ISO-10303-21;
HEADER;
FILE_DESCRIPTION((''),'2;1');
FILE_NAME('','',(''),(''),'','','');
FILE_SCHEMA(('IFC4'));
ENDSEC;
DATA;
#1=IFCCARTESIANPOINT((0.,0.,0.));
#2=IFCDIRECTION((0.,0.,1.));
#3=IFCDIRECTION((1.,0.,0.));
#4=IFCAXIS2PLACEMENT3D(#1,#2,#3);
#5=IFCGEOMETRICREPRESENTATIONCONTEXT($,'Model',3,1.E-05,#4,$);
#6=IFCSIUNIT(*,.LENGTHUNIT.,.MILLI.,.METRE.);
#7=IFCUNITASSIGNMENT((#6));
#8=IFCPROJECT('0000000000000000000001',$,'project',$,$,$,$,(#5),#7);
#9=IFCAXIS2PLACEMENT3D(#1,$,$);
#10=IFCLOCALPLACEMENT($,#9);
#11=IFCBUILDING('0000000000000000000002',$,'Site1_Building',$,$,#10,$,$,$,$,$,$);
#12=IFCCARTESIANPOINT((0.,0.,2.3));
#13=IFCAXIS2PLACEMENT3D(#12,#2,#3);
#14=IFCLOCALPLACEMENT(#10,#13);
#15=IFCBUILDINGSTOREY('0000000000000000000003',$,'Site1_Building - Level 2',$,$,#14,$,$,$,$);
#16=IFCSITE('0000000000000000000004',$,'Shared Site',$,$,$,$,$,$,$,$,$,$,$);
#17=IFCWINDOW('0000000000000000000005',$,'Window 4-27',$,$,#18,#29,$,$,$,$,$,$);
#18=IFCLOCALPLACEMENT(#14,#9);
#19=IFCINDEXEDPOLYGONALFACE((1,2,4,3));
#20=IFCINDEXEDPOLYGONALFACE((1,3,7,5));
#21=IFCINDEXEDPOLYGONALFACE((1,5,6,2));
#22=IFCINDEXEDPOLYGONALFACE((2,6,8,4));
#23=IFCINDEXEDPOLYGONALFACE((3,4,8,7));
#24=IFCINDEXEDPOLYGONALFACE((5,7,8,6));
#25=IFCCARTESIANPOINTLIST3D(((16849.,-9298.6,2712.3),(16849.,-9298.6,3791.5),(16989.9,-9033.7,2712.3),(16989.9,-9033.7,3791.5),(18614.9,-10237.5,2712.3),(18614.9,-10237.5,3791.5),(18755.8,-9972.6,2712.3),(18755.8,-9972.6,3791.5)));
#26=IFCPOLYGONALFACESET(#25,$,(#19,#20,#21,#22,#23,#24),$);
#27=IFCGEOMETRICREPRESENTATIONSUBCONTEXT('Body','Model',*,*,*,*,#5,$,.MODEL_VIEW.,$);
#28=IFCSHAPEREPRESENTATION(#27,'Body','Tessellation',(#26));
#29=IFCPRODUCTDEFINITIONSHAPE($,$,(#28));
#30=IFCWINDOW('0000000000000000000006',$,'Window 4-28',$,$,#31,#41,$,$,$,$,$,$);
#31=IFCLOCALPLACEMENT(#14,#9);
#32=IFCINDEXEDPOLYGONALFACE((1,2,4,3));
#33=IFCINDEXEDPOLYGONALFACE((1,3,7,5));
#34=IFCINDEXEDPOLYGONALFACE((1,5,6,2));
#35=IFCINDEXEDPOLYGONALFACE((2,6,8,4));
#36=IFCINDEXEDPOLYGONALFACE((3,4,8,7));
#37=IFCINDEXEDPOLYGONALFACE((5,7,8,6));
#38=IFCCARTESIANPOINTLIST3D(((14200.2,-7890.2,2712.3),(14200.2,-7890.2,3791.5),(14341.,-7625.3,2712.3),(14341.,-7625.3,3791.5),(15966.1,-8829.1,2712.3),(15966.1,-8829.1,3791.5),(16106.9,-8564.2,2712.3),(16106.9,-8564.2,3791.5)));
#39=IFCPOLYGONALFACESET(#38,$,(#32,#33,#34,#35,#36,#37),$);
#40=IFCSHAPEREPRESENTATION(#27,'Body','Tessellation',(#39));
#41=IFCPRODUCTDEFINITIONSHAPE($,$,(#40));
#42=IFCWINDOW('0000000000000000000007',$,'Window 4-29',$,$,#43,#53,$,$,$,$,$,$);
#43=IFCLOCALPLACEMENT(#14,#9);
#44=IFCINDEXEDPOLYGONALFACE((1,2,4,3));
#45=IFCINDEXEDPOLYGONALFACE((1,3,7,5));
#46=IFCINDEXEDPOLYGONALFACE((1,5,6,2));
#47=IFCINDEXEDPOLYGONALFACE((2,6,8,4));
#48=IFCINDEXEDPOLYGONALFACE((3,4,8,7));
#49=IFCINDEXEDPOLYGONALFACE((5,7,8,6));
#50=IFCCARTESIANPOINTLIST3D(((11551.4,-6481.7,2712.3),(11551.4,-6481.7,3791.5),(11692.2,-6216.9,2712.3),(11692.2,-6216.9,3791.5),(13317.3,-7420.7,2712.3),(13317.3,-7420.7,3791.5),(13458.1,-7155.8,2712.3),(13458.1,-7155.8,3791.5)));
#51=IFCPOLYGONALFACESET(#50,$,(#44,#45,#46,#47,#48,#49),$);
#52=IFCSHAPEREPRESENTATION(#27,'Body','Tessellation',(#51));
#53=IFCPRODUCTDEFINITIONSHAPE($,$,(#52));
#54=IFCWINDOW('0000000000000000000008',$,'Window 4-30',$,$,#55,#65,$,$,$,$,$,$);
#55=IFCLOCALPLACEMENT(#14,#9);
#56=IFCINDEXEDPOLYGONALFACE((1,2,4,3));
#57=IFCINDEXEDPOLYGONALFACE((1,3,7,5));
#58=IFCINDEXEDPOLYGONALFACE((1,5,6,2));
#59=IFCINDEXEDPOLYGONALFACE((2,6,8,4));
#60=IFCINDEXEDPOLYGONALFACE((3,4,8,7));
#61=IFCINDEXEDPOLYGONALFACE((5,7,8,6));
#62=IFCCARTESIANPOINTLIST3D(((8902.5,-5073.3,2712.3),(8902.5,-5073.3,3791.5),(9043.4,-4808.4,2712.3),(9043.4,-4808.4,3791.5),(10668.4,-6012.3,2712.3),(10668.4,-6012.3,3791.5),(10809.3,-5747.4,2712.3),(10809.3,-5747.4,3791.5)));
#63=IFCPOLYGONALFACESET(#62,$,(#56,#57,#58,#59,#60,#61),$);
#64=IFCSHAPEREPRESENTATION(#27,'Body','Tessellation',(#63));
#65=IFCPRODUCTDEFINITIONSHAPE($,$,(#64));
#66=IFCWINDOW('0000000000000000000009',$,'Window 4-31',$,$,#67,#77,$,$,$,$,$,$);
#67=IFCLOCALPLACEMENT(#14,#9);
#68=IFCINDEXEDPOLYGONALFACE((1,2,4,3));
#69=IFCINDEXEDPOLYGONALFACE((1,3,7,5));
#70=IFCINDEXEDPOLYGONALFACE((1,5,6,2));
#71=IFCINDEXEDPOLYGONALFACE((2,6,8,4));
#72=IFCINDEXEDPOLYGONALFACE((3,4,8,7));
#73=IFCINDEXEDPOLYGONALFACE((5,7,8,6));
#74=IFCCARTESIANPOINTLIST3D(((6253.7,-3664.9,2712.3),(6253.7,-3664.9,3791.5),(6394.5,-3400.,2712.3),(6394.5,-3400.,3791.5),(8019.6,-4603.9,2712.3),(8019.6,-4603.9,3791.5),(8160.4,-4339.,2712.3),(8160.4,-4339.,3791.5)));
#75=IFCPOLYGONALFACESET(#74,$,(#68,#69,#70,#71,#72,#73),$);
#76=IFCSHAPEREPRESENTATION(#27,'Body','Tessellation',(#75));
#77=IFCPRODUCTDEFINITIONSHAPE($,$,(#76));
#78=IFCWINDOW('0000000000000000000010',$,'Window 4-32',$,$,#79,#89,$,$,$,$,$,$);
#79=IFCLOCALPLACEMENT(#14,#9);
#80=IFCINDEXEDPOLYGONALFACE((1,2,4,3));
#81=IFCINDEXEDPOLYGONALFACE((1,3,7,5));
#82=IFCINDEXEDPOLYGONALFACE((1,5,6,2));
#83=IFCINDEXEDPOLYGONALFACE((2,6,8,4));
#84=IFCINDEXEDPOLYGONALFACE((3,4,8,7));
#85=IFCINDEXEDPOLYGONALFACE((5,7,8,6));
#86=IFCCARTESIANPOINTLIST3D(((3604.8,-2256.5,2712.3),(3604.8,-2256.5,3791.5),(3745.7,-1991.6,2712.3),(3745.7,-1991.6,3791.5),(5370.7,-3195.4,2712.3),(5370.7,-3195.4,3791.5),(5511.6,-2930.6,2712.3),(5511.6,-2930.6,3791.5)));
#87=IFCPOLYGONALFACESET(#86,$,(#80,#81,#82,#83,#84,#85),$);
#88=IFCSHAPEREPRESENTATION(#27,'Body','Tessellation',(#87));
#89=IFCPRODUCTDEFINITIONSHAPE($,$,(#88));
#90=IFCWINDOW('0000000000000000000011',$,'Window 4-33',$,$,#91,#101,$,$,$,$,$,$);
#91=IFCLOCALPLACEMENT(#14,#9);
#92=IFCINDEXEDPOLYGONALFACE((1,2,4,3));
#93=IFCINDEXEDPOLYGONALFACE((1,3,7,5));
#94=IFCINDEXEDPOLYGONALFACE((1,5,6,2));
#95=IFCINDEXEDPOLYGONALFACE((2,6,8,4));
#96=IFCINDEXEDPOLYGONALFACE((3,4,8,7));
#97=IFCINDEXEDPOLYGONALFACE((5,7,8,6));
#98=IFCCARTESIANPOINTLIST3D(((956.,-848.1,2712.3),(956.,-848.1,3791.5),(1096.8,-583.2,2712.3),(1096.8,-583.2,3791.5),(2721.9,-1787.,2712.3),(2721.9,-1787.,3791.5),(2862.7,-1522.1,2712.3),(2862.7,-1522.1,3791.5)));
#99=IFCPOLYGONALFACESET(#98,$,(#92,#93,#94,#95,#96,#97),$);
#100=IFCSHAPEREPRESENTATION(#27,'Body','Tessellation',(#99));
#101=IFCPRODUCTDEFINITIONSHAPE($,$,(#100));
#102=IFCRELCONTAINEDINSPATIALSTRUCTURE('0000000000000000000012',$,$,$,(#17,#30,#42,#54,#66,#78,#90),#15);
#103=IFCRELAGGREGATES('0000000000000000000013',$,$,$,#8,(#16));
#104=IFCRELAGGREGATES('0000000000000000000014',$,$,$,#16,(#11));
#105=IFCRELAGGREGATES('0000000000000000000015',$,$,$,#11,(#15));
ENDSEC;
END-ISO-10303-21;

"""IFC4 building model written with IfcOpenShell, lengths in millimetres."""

from ifc_helpers import new_model, si_unit, frame, origin, origin_with_axes, place, context, subcontext, project, spatial, indexed_curve, outline, extrude, element, save


model = new_model("IFC4")

# Units and contexts
model_context = context("Model", 3, precision=1e-05, world=origin_with_axes())
body_context = subcontext(model_context, "Body", "Model", "MODEL_VIEW")
ifc_project = project(units=[si_unit("LENGTHUNIT", "METRE", prefix="MILLI")], contexts=[model_context])

# Site, building, storey
site = spatial("IfcSite", under=ifc_project, Name="Shared Site")
building_placement = place(None, origin())
building = spatial("IfcBuilding", under=site, at=building_placement, Name="Site1_Building")
storey_placement = place(building_placement, frame((0.0, 0.0, 2.3), z_axis=(0.0, 0.0, 1.0), x_axis=(1.0, 0.0, 0.0)))
storey = spatial("IfcBuildingStorey", under=building, at=storey_placement, Name="Site1_Building - Level 2")

# Windows
for number, where, z_axis, x_axis, name in (
    (1, (18755.8, -9972.6, 2712.3), (0.0, 0.0, 1.0), (-0.882948, 0.469472, 0.0), "Window 4-27"),
    (2, (16106.9, -8564.2, 2712.3), (0.0, 0.0, 1.0), (-0.882948, 0.469472, 0.0), "Window 4-28"),
    (3, (13458.1, -7155.8, 2712.3), (0.0, 0.0, 1.0), (-0.882948, 0.469472, 0.0), "Window 4-29"),
    (4, (10809.3, -5747.4, 2712.3), (0.0, 0.0, 1.0), (-0.882948, 0.469472, 0.0), "Window 4-30"),
    (5, (8160.4, -4339.0, 2712.3), (0.0, 0.0, 1.0), (-0.882948, 0.469472, 0.0), "Window 4-31"),
    (6, (5511.6, -2930.6, 2712.3), (0.0, 0.0, 1.0), (-0.882948, 0.469472, 0.0), "Window 4-32"),
    (7, (2862.7, -1522.1, 2712.3), (0.0, 0.0, 1.0), (-0.882948, 0.469472, 0.0), "Window 4-33"),
):
    element("IfcWindow", number, at=place(storey_placement, frame(where, z_axis=z_axis, x_axis=x_axis)), inside=storey, Name=name, context=body_context, shape_type="SweptSolid", body=[
        extrude(outline(indexed_curve([(0.0, 0.0), (0.0, 300.0), (2000.0, 300.0), (2000.0, 0.0), (0.0, 0.0)], self_intersect=False)), origin_with_axes(), (0.0, 0.0, 1.0), 1079.3),
    ])

save(model, "model.ifc")
